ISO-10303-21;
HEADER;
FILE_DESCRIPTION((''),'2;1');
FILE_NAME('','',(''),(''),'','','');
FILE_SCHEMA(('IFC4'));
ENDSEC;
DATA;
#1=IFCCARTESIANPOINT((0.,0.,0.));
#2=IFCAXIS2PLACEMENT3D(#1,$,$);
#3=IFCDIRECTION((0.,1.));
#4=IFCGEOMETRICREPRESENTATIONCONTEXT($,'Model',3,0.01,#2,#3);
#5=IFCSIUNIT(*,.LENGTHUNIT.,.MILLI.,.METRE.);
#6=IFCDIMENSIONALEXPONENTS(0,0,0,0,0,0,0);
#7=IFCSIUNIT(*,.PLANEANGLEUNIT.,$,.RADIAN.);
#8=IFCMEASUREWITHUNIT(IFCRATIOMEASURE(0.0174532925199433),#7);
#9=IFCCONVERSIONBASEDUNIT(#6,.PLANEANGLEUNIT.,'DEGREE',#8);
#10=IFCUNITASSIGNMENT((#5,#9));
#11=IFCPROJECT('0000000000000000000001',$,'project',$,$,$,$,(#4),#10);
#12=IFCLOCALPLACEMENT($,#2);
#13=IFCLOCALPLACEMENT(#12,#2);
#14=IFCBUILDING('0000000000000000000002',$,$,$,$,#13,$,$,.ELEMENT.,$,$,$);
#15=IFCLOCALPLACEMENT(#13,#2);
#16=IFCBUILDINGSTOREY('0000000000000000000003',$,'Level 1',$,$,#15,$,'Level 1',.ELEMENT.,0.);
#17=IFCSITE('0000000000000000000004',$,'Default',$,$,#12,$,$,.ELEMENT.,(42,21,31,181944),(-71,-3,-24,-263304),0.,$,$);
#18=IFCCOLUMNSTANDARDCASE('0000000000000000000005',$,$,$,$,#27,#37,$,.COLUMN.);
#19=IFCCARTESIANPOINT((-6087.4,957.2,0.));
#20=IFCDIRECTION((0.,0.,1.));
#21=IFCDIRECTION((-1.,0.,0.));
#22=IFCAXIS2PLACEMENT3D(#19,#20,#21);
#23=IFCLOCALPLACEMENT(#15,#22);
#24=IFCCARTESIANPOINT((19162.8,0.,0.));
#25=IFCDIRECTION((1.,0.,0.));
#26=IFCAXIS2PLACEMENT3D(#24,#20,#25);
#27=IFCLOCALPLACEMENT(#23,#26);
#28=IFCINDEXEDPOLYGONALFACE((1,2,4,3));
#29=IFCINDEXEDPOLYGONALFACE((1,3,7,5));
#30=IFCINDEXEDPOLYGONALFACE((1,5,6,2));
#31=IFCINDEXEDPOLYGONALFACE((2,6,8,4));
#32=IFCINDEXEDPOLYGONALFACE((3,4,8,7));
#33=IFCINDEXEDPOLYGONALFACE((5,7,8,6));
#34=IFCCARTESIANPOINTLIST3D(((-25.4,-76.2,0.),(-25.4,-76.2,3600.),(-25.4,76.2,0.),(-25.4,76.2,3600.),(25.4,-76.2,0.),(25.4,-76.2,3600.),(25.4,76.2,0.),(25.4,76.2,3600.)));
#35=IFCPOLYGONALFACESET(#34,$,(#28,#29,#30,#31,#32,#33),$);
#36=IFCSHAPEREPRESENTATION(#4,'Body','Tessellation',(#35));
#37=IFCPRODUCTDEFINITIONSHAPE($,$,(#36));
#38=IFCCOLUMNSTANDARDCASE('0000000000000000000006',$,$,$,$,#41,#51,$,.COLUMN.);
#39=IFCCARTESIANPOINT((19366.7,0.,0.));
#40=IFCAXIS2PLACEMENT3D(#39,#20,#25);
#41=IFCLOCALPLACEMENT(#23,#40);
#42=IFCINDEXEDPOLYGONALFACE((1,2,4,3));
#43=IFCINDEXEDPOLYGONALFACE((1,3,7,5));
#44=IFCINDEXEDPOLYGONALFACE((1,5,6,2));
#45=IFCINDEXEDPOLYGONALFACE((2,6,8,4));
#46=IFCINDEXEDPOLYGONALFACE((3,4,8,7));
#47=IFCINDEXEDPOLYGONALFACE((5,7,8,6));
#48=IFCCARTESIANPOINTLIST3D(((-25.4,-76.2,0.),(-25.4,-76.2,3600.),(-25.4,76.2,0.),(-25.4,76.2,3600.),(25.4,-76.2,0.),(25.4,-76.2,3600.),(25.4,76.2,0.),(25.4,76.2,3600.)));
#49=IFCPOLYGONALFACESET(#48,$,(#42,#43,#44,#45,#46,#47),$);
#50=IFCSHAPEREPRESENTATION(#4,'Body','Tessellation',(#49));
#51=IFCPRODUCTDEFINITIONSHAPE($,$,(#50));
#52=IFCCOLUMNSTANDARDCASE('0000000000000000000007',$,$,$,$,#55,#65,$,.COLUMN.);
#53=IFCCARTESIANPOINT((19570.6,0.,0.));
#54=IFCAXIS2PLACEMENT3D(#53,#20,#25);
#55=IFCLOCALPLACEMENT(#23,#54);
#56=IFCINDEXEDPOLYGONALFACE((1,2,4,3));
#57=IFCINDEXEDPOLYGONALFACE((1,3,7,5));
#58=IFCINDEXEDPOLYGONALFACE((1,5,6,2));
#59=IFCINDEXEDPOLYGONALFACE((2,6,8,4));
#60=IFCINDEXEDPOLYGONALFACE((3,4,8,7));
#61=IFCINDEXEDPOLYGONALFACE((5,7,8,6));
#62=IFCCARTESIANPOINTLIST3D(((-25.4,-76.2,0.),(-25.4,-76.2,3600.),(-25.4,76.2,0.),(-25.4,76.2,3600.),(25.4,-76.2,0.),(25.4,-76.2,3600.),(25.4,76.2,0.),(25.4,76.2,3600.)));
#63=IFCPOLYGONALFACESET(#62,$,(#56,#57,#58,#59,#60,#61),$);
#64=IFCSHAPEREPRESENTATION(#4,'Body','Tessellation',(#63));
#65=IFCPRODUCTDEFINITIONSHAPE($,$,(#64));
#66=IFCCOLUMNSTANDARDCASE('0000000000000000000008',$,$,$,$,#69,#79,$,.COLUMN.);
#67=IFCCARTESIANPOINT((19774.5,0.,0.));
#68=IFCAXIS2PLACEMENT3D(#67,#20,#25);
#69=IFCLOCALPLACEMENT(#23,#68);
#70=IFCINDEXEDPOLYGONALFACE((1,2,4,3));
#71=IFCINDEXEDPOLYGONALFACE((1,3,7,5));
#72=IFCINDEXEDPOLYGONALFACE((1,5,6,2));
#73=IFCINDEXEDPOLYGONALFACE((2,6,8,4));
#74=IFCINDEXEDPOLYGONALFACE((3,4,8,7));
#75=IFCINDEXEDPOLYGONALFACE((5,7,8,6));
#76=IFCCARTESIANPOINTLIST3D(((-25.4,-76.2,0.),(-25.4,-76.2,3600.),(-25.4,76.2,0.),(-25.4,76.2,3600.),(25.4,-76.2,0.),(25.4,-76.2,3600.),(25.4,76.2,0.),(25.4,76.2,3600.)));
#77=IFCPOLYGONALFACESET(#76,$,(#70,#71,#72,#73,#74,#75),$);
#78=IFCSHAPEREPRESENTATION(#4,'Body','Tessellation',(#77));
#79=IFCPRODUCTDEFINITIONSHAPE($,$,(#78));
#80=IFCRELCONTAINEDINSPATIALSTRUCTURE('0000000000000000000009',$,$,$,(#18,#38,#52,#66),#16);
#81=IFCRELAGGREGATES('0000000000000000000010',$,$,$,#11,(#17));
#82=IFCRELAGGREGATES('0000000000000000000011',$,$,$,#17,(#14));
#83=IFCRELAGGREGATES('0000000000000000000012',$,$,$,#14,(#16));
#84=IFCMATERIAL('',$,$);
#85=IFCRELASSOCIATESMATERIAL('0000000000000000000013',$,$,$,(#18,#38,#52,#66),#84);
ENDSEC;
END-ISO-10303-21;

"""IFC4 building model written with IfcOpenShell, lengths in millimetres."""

from ifc_helpers import new_model, entity, si_unit, converted_unit, direction, frame, origin, place, context, project, spatial, rectangle, extrude, material, element, save


model = new_model("IFC4")

# Units and contexts
model_context = context("Model", 3, precision=0.01, world=origin(), true_north=direction((0.0, 1.0)))
ifc_project = project(units=[si_unit("LENGTHUNIT", "METRE", prefix="MILLI"), converted_unit("PLANEANGLEUNIT", "DEGREE", entity("IfcRatioMeasure", 0.0174532925199433), si_unit("PLANEANGLEUNIT", "RADIAN"), dimensions=[0, 0, 0, 0, 0, 0, 0])], contexts=[model_context])

# Site, building, storey
site_placement = place(None, origin())
site = spatial("IfcSite", under=ifc_project, at=site_placement, Name="Default", CompositionType="ELEMENT", RefLatitude=(42, 21, 31, 181944), RefLongitude=(-71, -3, -24, -263304), RefElevation=0.0)
building_placement = place(site_placement, origin())
building = spatial("IfcBuilding", under=site, at=building_placement, CompositionType="ELEMENT")
storey_placement = place(building_placement, origin())
storey = spatial("IfcBuildingStorey", under=building, at=storey_placement, Name="Level 1", LongName="Level 1", CompositionType="ELEMENT", Elevation=0.0)

# Columns
ifc_material_1 = material(Name="")
placement_1 = place(storey_placement, frame((-6087.4, 957.2, 0.0), z_axis=(0.0, 0.0, 1.0), x_axis=(-1.0, 0.0, 0.0)))
for number, where, z_axis, x_axis in (
    (1, (19162.8, 0.0, 0.0), (0.0, 0.0, 1.0), (1.0, 0.0, 0.0)),
    (2, (19366.7, 0.0, 0.0), (0.0, 0.0, 1.0), (1.0, 0.0, 0.0)),
    (3, (19570.6, 0.0, 0.0), (0.0, 0.0, 1.0), (1.0, 0.0, 0.0)),
    (4, (19774.5, 0.0, 0.0), (0.0, 0.0, 1.0), (1.0, 0.0, 0.0)),
):
    element("IfcColumnStandardCase", number, at=place(placement_1, frame(where, z_axis=z_axis, x_axis=x_axis)), inside=storey, material=ifc_material_1, PredefinedType="COLUMN", context=model_context, shape_type="SweptSolid", body=[
        extrude(rectangle(XDim=50.8, YDim=152.4), origin(), (0.0, 0.0, 1.0), 3600.0),
    ])

save(model, "model.ifc")
